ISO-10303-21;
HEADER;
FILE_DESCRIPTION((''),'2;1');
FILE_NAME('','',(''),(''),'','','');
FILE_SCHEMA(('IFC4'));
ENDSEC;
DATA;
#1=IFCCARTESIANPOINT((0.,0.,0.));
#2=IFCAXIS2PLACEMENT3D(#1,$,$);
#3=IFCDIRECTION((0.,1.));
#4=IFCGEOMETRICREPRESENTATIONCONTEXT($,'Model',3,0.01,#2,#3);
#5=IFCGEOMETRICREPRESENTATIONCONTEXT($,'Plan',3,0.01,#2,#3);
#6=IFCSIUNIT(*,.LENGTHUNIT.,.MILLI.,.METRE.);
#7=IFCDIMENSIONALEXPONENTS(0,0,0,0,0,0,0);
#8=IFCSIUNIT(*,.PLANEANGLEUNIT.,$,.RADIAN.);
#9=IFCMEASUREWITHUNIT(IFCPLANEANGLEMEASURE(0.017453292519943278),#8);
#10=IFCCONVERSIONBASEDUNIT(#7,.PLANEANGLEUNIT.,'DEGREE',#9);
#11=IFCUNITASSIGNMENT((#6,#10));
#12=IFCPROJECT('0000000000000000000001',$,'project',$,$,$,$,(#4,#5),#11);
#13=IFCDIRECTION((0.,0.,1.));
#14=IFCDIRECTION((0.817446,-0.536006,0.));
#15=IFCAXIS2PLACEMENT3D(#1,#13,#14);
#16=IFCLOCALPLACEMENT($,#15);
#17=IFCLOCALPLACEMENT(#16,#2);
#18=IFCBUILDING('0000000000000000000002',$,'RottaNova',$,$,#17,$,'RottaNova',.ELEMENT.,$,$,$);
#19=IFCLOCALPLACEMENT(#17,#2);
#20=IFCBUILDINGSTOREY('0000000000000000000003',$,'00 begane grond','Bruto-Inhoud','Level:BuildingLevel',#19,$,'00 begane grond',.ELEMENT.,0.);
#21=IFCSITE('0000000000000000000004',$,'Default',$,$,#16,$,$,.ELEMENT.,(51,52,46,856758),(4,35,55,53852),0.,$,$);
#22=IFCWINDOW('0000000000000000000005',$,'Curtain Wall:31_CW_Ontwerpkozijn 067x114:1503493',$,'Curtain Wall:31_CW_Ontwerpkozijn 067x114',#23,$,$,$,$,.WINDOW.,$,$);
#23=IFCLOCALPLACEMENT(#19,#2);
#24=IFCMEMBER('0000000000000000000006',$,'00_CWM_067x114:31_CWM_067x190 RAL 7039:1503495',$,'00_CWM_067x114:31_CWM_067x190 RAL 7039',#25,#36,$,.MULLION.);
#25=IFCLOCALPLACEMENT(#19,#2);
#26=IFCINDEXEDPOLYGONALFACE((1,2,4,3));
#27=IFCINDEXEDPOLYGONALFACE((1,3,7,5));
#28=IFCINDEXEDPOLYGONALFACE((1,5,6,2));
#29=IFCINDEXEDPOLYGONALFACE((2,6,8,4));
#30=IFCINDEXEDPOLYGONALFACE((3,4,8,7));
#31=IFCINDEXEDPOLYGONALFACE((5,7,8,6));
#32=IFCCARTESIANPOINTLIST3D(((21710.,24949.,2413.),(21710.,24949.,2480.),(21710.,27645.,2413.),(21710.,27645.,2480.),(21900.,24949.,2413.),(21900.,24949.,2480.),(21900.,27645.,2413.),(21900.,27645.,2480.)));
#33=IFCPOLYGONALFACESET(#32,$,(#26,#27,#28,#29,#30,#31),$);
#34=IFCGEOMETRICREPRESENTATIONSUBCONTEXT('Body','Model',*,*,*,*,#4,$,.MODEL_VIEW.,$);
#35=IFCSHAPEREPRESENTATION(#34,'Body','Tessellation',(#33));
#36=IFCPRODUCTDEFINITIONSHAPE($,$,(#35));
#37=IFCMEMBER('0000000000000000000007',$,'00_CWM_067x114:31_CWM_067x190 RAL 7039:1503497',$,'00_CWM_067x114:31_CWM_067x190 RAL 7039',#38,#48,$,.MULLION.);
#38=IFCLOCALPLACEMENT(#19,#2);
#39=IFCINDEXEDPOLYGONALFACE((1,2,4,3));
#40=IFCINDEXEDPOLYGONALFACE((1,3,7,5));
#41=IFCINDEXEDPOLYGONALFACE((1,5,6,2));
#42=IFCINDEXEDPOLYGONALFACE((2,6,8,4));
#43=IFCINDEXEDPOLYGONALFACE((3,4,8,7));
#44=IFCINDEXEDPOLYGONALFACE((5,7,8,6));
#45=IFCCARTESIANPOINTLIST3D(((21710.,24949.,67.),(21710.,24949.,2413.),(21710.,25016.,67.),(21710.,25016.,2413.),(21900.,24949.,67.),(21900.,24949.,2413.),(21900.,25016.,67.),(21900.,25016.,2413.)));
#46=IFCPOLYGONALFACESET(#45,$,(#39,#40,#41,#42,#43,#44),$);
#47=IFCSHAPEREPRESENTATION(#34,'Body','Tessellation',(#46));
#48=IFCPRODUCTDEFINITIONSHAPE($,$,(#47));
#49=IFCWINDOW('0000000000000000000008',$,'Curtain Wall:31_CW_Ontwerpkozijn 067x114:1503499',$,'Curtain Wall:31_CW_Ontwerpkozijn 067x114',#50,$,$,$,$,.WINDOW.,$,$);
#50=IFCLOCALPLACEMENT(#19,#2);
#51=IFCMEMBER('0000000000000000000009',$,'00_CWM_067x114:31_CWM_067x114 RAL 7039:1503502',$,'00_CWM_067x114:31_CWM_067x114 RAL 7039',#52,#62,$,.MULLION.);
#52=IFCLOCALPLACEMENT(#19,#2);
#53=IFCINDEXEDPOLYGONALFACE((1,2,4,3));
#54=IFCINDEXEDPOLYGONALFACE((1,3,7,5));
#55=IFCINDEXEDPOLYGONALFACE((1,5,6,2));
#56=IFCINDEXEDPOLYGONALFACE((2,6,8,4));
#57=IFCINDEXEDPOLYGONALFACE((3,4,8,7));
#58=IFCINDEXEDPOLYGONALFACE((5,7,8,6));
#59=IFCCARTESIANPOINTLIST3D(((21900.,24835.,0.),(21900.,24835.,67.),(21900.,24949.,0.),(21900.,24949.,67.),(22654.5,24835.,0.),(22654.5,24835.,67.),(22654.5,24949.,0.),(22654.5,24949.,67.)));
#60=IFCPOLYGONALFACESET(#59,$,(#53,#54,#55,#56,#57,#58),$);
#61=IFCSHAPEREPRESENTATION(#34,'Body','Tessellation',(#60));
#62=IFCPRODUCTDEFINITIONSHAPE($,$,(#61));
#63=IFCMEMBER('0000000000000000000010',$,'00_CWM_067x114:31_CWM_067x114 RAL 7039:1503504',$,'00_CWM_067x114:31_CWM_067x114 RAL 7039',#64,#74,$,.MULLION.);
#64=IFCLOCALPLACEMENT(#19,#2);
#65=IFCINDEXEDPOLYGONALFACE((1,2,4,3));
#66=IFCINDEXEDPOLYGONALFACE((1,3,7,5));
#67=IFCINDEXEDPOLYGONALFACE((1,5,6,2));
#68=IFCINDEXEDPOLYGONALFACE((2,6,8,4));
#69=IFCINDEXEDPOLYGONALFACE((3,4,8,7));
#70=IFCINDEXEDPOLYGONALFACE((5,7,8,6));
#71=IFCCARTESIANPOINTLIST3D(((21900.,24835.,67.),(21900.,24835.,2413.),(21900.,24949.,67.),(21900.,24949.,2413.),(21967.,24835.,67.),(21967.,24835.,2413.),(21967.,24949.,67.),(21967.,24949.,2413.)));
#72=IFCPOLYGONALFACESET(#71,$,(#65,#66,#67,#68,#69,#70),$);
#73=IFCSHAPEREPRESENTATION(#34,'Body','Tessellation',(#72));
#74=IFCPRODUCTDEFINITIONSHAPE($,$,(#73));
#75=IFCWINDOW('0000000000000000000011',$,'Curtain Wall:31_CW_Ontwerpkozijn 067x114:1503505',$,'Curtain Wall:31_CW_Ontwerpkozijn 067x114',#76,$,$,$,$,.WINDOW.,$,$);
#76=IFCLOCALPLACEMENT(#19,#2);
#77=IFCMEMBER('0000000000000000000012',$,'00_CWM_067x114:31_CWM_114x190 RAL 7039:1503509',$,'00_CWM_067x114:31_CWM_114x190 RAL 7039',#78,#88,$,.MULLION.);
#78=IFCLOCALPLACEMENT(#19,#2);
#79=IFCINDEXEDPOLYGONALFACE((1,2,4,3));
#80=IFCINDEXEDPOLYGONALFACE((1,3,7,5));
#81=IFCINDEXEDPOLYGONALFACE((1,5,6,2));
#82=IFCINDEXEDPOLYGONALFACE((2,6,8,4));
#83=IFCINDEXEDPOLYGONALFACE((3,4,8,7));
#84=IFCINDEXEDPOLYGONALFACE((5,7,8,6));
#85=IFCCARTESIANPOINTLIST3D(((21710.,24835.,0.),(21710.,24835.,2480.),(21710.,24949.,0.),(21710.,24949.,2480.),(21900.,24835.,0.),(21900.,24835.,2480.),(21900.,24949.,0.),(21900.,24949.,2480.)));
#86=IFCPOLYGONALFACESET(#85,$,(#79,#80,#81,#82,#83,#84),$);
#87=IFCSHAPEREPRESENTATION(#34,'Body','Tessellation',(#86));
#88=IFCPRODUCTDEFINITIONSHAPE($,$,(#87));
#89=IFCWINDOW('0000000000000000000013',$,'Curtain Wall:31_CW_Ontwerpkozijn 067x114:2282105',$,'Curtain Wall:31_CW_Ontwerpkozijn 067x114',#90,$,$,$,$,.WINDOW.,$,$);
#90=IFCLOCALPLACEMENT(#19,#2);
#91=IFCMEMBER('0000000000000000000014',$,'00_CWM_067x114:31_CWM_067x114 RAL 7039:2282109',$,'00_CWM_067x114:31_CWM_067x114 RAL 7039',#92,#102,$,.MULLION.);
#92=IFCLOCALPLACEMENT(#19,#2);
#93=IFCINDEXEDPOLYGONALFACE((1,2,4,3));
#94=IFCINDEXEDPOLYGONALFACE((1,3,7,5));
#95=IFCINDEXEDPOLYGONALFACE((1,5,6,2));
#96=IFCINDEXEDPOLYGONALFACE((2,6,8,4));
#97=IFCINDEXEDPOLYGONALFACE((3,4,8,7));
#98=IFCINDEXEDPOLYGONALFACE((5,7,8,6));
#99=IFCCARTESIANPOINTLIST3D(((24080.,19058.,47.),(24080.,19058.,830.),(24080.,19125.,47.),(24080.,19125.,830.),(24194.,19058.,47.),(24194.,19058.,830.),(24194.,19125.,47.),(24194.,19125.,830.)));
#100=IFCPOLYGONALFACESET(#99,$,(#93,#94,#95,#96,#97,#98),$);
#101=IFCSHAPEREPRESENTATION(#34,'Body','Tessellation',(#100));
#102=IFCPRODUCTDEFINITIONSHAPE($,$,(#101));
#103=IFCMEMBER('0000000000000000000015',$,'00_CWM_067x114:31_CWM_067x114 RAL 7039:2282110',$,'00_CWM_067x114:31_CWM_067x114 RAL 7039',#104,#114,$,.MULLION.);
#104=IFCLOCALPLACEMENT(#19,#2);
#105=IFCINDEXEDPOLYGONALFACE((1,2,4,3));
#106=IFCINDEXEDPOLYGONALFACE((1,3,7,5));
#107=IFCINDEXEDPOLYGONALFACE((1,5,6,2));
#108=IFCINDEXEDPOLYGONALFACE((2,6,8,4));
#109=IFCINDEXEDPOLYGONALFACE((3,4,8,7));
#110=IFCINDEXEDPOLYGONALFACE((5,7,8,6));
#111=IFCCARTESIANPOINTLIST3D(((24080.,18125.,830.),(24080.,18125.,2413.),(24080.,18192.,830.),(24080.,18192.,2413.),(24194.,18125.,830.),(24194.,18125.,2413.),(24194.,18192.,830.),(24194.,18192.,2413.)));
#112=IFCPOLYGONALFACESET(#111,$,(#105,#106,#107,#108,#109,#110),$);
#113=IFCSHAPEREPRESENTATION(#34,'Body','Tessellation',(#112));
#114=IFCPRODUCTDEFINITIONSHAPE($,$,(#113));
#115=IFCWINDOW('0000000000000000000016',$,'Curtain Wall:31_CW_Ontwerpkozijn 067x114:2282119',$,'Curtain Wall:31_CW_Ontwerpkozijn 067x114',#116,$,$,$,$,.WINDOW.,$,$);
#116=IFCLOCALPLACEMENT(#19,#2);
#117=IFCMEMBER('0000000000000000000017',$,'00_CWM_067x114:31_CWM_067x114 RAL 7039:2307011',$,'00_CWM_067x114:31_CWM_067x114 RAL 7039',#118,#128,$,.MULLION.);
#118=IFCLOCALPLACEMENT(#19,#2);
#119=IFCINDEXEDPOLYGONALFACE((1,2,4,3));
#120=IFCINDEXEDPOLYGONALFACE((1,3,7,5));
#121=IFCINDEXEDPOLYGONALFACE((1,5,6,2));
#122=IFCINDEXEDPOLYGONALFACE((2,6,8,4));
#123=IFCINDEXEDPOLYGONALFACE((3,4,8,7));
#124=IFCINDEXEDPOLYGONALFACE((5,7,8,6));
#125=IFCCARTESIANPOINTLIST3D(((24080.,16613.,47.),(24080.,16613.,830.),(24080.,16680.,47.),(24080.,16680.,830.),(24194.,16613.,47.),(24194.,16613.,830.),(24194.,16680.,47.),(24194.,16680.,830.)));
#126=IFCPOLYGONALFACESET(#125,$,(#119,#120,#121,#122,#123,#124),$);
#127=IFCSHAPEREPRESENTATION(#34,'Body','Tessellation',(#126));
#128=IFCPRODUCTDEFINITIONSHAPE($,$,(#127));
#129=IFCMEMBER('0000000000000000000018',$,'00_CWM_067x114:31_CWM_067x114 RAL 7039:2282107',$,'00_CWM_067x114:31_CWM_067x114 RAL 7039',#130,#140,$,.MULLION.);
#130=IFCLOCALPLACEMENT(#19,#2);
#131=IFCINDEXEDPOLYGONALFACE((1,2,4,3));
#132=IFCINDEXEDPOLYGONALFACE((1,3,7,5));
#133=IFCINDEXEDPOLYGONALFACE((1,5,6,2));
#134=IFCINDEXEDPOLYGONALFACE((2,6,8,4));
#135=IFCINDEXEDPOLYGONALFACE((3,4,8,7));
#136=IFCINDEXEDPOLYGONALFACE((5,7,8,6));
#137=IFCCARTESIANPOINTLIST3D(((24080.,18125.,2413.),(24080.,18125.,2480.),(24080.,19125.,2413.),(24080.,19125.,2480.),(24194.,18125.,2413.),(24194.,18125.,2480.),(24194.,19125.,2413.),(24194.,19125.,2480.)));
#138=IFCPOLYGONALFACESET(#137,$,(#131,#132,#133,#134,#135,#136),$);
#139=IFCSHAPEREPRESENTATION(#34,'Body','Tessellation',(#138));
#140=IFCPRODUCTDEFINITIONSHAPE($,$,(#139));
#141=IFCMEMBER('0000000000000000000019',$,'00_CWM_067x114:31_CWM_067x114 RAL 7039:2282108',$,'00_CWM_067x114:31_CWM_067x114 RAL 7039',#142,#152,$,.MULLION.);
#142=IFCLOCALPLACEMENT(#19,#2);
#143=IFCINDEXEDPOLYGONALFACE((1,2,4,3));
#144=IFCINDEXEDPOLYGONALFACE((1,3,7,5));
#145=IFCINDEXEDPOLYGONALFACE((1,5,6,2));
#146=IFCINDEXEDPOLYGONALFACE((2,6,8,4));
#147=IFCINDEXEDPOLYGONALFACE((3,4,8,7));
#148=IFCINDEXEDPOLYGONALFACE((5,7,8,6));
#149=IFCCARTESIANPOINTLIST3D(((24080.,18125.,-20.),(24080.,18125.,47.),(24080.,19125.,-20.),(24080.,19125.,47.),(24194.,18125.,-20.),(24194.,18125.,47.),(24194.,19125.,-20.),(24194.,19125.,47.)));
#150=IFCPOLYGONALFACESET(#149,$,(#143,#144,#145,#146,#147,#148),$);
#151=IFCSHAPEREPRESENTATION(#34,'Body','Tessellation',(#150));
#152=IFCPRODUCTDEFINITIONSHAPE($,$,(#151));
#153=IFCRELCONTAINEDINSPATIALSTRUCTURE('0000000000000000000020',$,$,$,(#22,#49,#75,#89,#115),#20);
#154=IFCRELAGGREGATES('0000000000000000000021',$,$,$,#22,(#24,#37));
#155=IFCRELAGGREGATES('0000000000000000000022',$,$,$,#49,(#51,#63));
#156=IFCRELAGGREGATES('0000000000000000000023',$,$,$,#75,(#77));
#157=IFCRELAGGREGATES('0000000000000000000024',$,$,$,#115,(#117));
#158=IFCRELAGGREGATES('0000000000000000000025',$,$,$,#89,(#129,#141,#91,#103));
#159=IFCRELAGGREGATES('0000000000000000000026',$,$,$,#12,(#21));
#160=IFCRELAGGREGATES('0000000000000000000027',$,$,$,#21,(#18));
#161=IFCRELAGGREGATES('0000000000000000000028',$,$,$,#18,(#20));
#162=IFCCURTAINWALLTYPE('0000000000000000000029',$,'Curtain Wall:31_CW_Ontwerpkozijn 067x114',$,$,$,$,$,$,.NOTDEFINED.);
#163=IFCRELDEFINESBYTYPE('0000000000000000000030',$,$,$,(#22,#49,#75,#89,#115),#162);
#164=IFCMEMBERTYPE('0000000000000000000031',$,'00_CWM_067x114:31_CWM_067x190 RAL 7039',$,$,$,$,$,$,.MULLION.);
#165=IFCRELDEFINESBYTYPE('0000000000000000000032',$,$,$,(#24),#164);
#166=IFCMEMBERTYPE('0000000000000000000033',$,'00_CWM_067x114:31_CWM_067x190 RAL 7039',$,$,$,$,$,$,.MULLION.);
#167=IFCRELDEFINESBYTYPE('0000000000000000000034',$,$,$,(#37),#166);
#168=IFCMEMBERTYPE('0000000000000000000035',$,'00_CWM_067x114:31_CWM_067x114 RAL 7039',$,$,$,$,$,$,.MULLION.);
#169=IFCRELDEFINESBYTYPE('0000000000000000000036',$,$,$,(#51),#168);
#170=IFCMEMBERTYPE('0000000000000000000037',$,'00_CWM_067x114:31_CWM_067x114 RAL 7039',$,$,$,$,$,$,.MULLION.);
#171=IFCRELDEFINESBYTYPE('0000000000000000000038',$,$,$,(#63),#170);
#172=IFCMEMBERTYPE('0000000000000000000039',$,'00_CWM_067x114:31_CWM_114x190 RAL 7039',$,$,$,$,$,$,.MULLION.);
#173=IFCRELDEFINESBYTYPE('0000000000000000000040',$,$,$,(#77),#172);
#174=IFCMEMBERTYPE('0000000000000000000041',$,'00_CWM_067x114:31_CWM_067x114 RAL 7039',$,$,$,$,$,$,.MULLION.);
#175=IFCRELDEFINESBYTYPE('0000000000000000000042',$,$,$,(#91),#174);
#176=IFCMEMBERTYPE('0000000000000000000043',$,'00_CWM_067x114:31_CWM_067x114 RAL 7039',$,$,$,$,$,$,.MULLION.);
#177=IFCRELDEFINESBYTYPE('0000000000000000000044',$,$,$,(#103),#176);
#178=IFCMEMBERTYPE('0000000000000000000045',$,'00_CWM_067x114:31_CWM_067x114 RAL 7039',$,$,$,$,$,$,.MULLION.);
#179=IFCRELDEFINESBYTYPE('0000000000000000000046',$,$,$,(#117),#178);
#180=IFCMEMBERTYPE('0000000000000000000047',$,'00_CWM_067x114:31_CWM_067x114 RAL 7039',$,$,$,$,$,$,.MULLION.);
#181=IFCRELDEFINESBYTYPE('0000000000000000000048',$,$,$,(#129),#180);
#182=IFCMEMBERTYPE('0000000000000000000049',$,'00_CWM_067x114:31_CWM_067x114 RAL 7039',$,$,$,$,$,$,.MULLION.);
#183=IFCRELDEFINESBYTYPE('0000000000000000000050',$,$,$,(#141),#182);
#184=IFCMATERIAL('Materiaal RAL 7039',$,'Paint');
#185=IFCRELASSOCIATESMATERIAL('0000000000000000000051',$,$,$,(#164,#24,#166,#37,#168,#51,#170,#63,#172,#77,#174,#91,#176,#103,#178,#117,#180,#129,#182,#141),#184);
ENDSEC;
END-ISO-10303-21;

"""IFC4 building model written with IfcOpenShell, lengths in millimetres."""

from ifc_helpers import new_model, entity, si_unit, converted_unit, direction, frame, origin, place, context, subcontext, project, spatial, indexed_curve, outline, extrude, source, transform, mapped, material, type_object, type_shapes, element, aggregate, save


model = new_model("IFC4")

# Units and contexts
model_context = context("Model", 3, precision=0.01, world=origin(), true_north=direction((0.0, 1.0)))
plan_context = context("Plan", 3, precision=0.01, world=origin(), true_north=direction((0.0, 1.0)))
body_context = subcontext(model_context, "Body", "Model", "MODEL_VIEW")
ifc_project = project(units=[si_unit("LENGTHUNIT", "METRE", prefix="MILLI"), converted_unit("PLANEANGLEUNIT", "DEGREE", entity("IfcPlaneAngleMeasure", 0.017453292519943278), si_unit("PLANEANGLEUNIT", "RADIAN"), dimensions=[0, 0, 0, 0, 0, 0, 0])], contexts=[model_context, plan_context])

# Site, building, storey
site_placement = place(None, frame((0.0, 0.0, 0.0), z_axis=(0.0, 0.0, 1.0), x_axis=(0.817446, -0.536006, 0.0)))
site = spatial("IfcSite", under=ifc_project, at=site_placement, Name="Default", CompositionType="ELEMENT", RefLatitude=(51, 52, 46, 856758), RefLongitude=(4, 35, 55, 53852), RefElevation=0.0)
building_placement = place(site_placement, origin())
building = spatial("IfcBuilding", under=site, at=building_placement, Name="RottaNova", LongName="RottaNova", CompositionType="ELEMENT")
storey_placement = place(building_placement, origin())
storey = spatial("IfcBuildingStorey", under=building, at=storey_placement, Name="00 begane grond", Description="Bruto-Inhoud", ObjectType="Level:BuildingLevel", LongName="00 begane grond", CompositionType="ELEMENT", Elevation=0.0)

# Windows, members
curtain_wall_type = type_object("IfcCurtainWallType", Name="Curtain Wall:31_CW_Ontwerpkozijn 067x114", PredefinedType="NOTDEFINED")
window_1_placement = place(storey_placement, origin())
window_1 = element("IfcWindow", 1, at=window_1_placement, inside=storey, type_object=curtain_wall_type, Name="Curtain Wall:31_CW_Ontwerpkozijn 067x114:1503493", ObjectType="Curtain Wall:31_CW_Ontwerpkozijn 067x114", PredefinedType="WINDOW")
ifc_material_1 = material(Name="Materiaal RAL 7039", Category="Paint")
member_type_1 = type_object("IfcMemberType", Name="00_CWM_067x114:31_CWM_067x190 RAL 7039", PredefinedType="MULLION", material=ifc_material_1)
shared_shape_1 = source(origin(), body_context, "Body", "SweptSolid", [
    extrude(outline(indexed_curve([(-33.5, -95.0), (33.5, -95.0), (33.5, 95.0), (-33.5, 95.0), (-33.5, -95.0)], self_intersect=False)), frame((-33.5, -95.0, -2696.0), z_axis=(0.0, 0.0, 1.0), x_axis=(-1.0, 0.0, 0.0)), (0.0, 0.0, 1.0), 2696.0),
])
type_shapes(member_type_1, [shared_shape_1])
member_1_placement = place(window_1_placement, frame((21710.0, 24949.0, 2480.0), z_axis=(0.0, -1.0, 0.0), x_axis=(0.0, 0.0, 1.0)))
member_1 = element("IfcMember", 2, at=member_1_placement, type_object=member_type_1, material=ifc_material_1, Name="00_CWM_067x114:31_CWM_067x190 RAL 7039:1503495", ObjectType="00_CWM_067x114:31_CWM_067x190 RAL 7039", PredefinedType="MULLION", context=body_context, shape_type="MappedRepresentation", body=[
    mapped(shared_shape_1, transform((0.0, 0.0, 0.0), scale=1.0)),
])
member_type_2 = type_object("IfcMemberType", Name="00_CWM_067x114:31_CWM_067x190 RAL 7039", PredefinedType="MULLION", material=ifc_material_1)
shared_shape_2 = source(origin(), body_context, "Body", "SweptSolid", [
    extrude(outline(indexed_curve([(-33.5, -95.0), (33.5, -95.0), (33.5, 95.0), (-33.5, 95.0), (-33.5, -95.0)], self_intersect=False)), frame((-33.5, -95.0, -2346.0), z_axis=(0.0, 0.0, 1.0), x_axis=(-1.0, 0.0, 0.0)), (0.0, 0.0, 1.0), 2346.0),
])
type_shapes(member_type_2, [shared_shape_2])
member_2_placement = place(window_1_placement, frame((21710.0, 24949.0, 67.0), z_axis=(0.0, 0.0, -1.0), x_axis=(0.0, -1.0, 0.0)))
member_2 = element("IfcMember", 3, at=member_2_placement, type_object=member_type_2, material=ifc_material_1, Name="00_CWM_067x114:31_CWM_067x190 RAL 7039:1503497", ObjectType="00_CWM_067x114:31_CWM_067x190 RAL 7039", PredefinedType="MULLION", context=body_context, shape_type="MappedRepresentation", body=[
    mapped(shared_shape_2, transform((0.0, 0.0, 0.0), scale=1.0)),
])
aggregate(window_1, [member_1, member_2])
window_2_placement = place(storey_placement, origin())
window_2 = element("IfcWindow", 4, at=window_2_placement, inside=storey, type_object=curtain_wall_type, Name="Curtain Wall:31_CW_Ontwerpkozijn 067x114:1503499", ObjectType="Curtain Wall:31_CW_Ontwerpkozijn 067x114", PredefinedType="WINDOW")
member_type_3 = type_object("IfcMemberType", Name="00_CWM_067x114:31_CWM_067x114 RAL 7039", PredefinedType="MULLION", material=ifc_material_1)
shared_shape_3 = source(origin(), body_context, "Body", "SweptSolid", [
    extrude(outline(indexed_curve([(-33.5, -57.0), (33.5, -57.0), (33.5, 57.0), (-33.5, 57.0), (-33.5, -57.0)], self_intersect=False)), frame((-33.5, -57.0, -754.5), z_axis=(0.0, 0.0, 1.0), x_axis=(-1.0, 0.0, 0.0)), (0.0, 0.0, 1.0), 754.5),
])
type_shapes(member_type_3, [shared_shape_3])
member_3_placement = place(window_2_placement, frame((21900.0, 24835.0, 0.0), z_axis=(-1.0, 0.0, 0.0), x_axis=(0.0, 0.0, -1.0)))
member_3 = element("IfcMember", 5, at=member_3_placement, type_object=member_type_3, material=ifc_material_1, Name="00_CWM_067x114:31_CWM_067x114 RAL 7039:1503502", ObjectType="00_CWM_067x114:31_CWM_067x114 RAL 7039", PredefinedType="MULLION", context=body_context, shape_type="MappedRepresentation", body=[
    mapped(shared_shape_3, transform((0.0, 0.0, 0.0), scale=1.0)),
])
member_type_4 = type_object("IfcMemberType", Name="00_CWM_067x114:31_CWM_067x114 RAL 7039", PredefinedType="MULLION", material=ifc_material_1)
shared_shape_4 = source(origin(), body_context, "Body", "SweptSolid", [
    extrude(outline(indexed_curve([(-33.5, -57.0), (33.5, -57.0), (33.5, 57.0), (-33.5, 57.0), (-33.5, -57.0)], self_intersect=False)), frame((-33.5, -57.0, -2346.0), z_axis=(0.0, 0.0, 1.0), x_axis=(-1.0, 0.0, 0.0)), (0.0, 0.0, 1.0), 2346.0),
])
type_shapes(member_type_4, [shared_shape_4])
member_4_placement = place(window_2_placement, frame((21900.0, 24835.0, 2413.0), z_axis=(0.0, 0.0, 1.0), x_axis=(-1.0, 0.0, 0.0)))
member_4 = element("IfcMember", 6, at=member_4_placement, type_object=member_type_4, material=ifc_material_1, Name="00_CWM_067x114:31_CWM_067x114 RAL 7039:1503504", ObjectType="00_CWM_067x114:31_CWM_067x114 RAL 7039", PredefinedType="MULLION", context=body_context, shape_type="MappedRepresentation", body=[
    mapped(shared_shape_4, transform((0.0, 0.0, 0.0), scale=1.0)),
])
aggregate(window_2, [member_3, member_4])

# Window, member
window_3_placement = place(storey_placement, origin())
window_3 = element("IfcWindow", 7, at=window_3_placement, inside=storey, type_object=curtain_wall_type, Name="Curtain Wall:31_CW_Ontwerpkozijn 067x114:1503505", ObjectType="Curtain Wall:31_CW_Ontwerpkozijn 067x114", PredefinedType="WINDOW")
member_type_5 = type_object("IfcMemberType", Name="00_CWM_067x114:31_CWM_114x190 RAL 7039", PredefinedType="MULLION", material=ifc_material_1)
shared_shape_5 = source(origin(), body_context, "Body", "SweptSolid", [
    extrude(outline(indexed_curve([(-95.0, -57.0), (95.0, -57.0), (95.0, 57.0), (-95.0, 57.0), (-95.0, -57.0)], self_intersect=False)), frame((-95.0, 0.0, -2480.0)), (0.0, 0.0, 1.0), 2480.0),
])
type_shapes(member_type_5, [shared_shape_5])
member_5_placement = place(window_3_placement, frame((21710.0, 24892.0, 2480.0), z_axis=(0.0, 0.0, 1.0), x_axis=(-1.0, 0.0, 0.0)))
member_5 = element("IfcMember", 8, at=member_5_placement, type_object=member_type_5, material=ifc_material_1, Name="00_CWM_067x114:31_CWM_114x190 RAL 7039:1503509", ObjectType="00_CWM_067x114:31_CWM_114x190 RAL 7039", PredefinedType="MULLION", context=body_context, shape_type="MappedRepresentation", body=[
    mapped(shared_shape_5, transform((0.0, 0.0, 0.0), scale=1.0)),
])
aggregate(window_3, [member_5])

# Window, members
window_4_placement = place(storey_placement, origin())
window_4 = element("IfcWindow", 9, at=window_4_placement, inside=storey, type_object=curtain_wall_type, Name="Curtain Wall:31_CW_Ontwerpkozijn 067x114:2282105", ObjectType="Curtain Wall:31_CW_Ontwerpkozijn 067x114", PredefinedType="WINDOW")
member_type_6 = type_object("IfcMemberType", Name="00_CWM_067x114:31_CWM_067x114 RAL 7039", PredefinedType="MULLION", material=ifc_material_1)
shared_shape_6 = source(origin(), body_context, "Body", "SweptSolid", [
    extrude(outline(indexed_curve([(-33.5, -57.0), (33.5, -57.0), (33.5, 57.0), (-33.5, 57.0), (-33.5, -57.0)], self_intersect=False)), frame((-33.5, 57.0, -783.0), z_axis=(0.0, 0.0, 1.0), x_axis=(-1.0, 0.0, 0.0)), (0.0, 0.0, 1.0), 783.0),
])
type_shapes(member_type_6, [shared_shape_6])
member_6_placement = place(window_4_placement, frame((24080.0, 19125.0, 47.0), z_axis=(0.0, 0.0, -1.0), x_axis=(0.0, 1.0, 0.0)))
member_6 = element("IfcMember", 10, at=member_6_placement, type_object=member_type_6, material=ifc_material_1, Name="00_CWM_067x114:31_CWM_067x114 RAL 7039:2282109", ObjectType="00_CWM_067x114:31_CWM_067x114 RAL 7039", PredefinedType="MULLION", context=body_context, shape_type="MappedRepresentation", body=[
    mapped(shared_shape_6, transform((0.0, 0.0, 0.0), scale=1.0)),
])
member_type_7 = type_object("IfcMemberType", Name="00_CWM_067x114:31_CWM_067x114 RAL 7039", PredefinedType="MULLION", material=ifc_material_1)
shared_shape_7 = source(origin(), body_context, "Body", "SweptSolid", [
    extrude(outline(indexed_curve([(-33.5, -57.0), (33.5, -57.0), (33.5, 57.0), (-33.5, 57.0), (-33.5, -57.0)], self_intersect=False)), frame((-33.5, 57.0, -1583.0), z_axis=(0.0, 0.0, 1.0), x_axis=(-1.0, 0.0, 0.0)), (0.0, 0.0, 1.0), 1583.0),
])
type_shapes(member_type_7, [shared_shape_7])
member_7_placement = place(window_4_placement, frame((24080.0, 18125.0, 2413.0), z_axis=(0.0, 0.0, 1.0), x_axis=(0.0, -1.0, 0.0)))
member_7 = element("IfcMember", 11, at=member_7_placement, type_object=member_type_7, material=ifc_material_1, Name="00_CWM_067x114:31_CWM_067x114 RAL 7039:2282110", ObjectType="00_CWM_067x114:31_CWM_067x114 RAL 7039", PredefinedType="MULLION", context=body_context, shape_type="MappedRepresentation", body=[
    mapped(shared_shape_7, transform((0.0, 0.0, 0.0), scale=1.0)),
])

# Window, member
window_5_placement = place(storey_placement, origin())
window_5 = element("IfcWindow", 12, at=window_5_placement, inside=storey, type_object=curtain_wall_type, Name="Curtain Wall:31_CW_Ontwerpkozijn 067x114:2282119", ObjectType="Curtain Wall:31_CW_Ontwerpkozijn 067x114", PredefinedType="WINDOW")
member_type_8 = type_object("IfcMemberType", Name="00_CWM_067x114:31_CWM_067x114 RAL 7039", PredefinedType="MULLION", material=ifc_material_1)
shared_shape_8 = source(origin(), body_context, "Body", "SweptSolid", [
    extrude(outline(indexed_curve([(-33.5, -57.0), (33.5, -57.0), (33.5, 57.0), (-33.5, 57.0), (-33.5, -57.0)], self_intersect=False)), frame((-33.5, -57.0, -783.0), z_axis=(0.0, 0.0, 1.0), x_axis=(-1.0, 0.0, 0.0)), (0.0, 0.0, 1.0), 783.0),
])
type_shapes(member_type_8, [shared_shape_8])
member_8_placement = place(window_5_placement, frame((24080.0, 16680.0, 830.0), z_axis=(0.0, 0.0, 1.0), x_axis=(0.0, 1.0, 0.0)))
member_8 = element("IfcMember", 13, at=member_8_placement, type_object=member_type_8, material=ifc_material_1, Name="00_CWM_067x114:31_CWM_067x114 RAL 7039:2307011", ObjectType="00_CWM_067x114:31_CWM_067x114 RAL 7039", PredefinedType="MULLION", context=body_context, shape_type="MappedRepresentation", body=[
    mapped(shared_shape_8, transform((0.0, 0.0, 0.0), scale=1.0)),
])

# Members
member_type_9 = type_object("IfcMemberType", Name="00_CWM_067x114:31_CWM_067x114 RAL 7039", PredefinedType="MULLION", material=ifc_material_1)
shared_shape_9 = source(origin(), body_context, "Body", "SweptSolid", [
    extrude(outline(indexed_curve([(-33.5, -57.0), (33.5, -57.0), (33.5, 57.0), (-33.5, 57.0), (-33.5, -57.0)], self_intersect=False)), frame((-33.5, 57.0, -1000.0), z_axis=(0.0, 0.0, 1.0), x_axis=(-1.0, 0.0, 0.0)), (0.0, 0.0, 1.0), 1000.0),
])
type_shapes(member_type_9, [shared_shape_9])
member_9_placement = place(window_4_placement, frame((24080.0, 19125.0, 2480.0), z_axis=(0.0, 1.0, 0.0), x_axis=(0.0, 0.0, 1.0)))
member_9 = element("IfcMember", 14, at=member_9_placement, type_object=member_type_9, material=ifc_material_1, Name="00_CWM_067x114:31_CWM_067x114 RAL 7039:2282107", ObjectType="00_CWM_067x114:31_CWM_067x114 RAL 7039", PredefinedType="MULLION", context=body_context, shape_type="MappedRepresentation", body=[
    mapped(shared_shape_9, transform((0.0, 0.0, 0.0), scale=1.0)),
])
member_type_10 = type_object("IfcMemberType", Name="00_CWM_067x114:31_CWM_067x114 RAL 7039", PredefinedType="MULLION", material=ifc_material_1)
shared_shape_10 = source(origin(), body_context, "Body", "SweptSolid", [
    extrude(outline(indexed_curve([(-33.5, -57.0), (33.5, -57.0), (33.5, 57.0), (-33.5, 57.0), (-33.5, -57.0)], self_intersect=False)), frame((-33.5, 57.0, -1000.0), z_axis=(0.0, 0.0, 1.0), x_axis=(-1.0, 0.0, 0.0)), (0.0, 0.0, 1.0), 1000.0),
])
type_shapes(member_type_10, [shared_shape_10])
member_10_placement = place(window_4_placement, frame((24080.0, 18125.0, -20.0), z_axis=(0.0, -1.0, 0.0), x_axis=(0.0, 0.0, -1.0)))
member_10 = element("IfcMember", 15, at=member_10_placement, type_object=member_type_10, material=ifc_material_1, Name="00_CWM_067x114:31_CWM_067x114 RAL 7039:2282108", ObjectType="00_CWM_067x114:31_CWM_067x114 RAL 7039", PredefinedType="MULLION", context=body_context, shape_type="MappedRepresentation", body=[
    mapped(shared_shape_10, transform((0.0, 0.0, 0.0), scale=1.0)),
])

aggregate(window_5, [member_8])

aggregate(window_4, [member_9, member_10, member_6, member_7])

save(model, "model.ifc")
